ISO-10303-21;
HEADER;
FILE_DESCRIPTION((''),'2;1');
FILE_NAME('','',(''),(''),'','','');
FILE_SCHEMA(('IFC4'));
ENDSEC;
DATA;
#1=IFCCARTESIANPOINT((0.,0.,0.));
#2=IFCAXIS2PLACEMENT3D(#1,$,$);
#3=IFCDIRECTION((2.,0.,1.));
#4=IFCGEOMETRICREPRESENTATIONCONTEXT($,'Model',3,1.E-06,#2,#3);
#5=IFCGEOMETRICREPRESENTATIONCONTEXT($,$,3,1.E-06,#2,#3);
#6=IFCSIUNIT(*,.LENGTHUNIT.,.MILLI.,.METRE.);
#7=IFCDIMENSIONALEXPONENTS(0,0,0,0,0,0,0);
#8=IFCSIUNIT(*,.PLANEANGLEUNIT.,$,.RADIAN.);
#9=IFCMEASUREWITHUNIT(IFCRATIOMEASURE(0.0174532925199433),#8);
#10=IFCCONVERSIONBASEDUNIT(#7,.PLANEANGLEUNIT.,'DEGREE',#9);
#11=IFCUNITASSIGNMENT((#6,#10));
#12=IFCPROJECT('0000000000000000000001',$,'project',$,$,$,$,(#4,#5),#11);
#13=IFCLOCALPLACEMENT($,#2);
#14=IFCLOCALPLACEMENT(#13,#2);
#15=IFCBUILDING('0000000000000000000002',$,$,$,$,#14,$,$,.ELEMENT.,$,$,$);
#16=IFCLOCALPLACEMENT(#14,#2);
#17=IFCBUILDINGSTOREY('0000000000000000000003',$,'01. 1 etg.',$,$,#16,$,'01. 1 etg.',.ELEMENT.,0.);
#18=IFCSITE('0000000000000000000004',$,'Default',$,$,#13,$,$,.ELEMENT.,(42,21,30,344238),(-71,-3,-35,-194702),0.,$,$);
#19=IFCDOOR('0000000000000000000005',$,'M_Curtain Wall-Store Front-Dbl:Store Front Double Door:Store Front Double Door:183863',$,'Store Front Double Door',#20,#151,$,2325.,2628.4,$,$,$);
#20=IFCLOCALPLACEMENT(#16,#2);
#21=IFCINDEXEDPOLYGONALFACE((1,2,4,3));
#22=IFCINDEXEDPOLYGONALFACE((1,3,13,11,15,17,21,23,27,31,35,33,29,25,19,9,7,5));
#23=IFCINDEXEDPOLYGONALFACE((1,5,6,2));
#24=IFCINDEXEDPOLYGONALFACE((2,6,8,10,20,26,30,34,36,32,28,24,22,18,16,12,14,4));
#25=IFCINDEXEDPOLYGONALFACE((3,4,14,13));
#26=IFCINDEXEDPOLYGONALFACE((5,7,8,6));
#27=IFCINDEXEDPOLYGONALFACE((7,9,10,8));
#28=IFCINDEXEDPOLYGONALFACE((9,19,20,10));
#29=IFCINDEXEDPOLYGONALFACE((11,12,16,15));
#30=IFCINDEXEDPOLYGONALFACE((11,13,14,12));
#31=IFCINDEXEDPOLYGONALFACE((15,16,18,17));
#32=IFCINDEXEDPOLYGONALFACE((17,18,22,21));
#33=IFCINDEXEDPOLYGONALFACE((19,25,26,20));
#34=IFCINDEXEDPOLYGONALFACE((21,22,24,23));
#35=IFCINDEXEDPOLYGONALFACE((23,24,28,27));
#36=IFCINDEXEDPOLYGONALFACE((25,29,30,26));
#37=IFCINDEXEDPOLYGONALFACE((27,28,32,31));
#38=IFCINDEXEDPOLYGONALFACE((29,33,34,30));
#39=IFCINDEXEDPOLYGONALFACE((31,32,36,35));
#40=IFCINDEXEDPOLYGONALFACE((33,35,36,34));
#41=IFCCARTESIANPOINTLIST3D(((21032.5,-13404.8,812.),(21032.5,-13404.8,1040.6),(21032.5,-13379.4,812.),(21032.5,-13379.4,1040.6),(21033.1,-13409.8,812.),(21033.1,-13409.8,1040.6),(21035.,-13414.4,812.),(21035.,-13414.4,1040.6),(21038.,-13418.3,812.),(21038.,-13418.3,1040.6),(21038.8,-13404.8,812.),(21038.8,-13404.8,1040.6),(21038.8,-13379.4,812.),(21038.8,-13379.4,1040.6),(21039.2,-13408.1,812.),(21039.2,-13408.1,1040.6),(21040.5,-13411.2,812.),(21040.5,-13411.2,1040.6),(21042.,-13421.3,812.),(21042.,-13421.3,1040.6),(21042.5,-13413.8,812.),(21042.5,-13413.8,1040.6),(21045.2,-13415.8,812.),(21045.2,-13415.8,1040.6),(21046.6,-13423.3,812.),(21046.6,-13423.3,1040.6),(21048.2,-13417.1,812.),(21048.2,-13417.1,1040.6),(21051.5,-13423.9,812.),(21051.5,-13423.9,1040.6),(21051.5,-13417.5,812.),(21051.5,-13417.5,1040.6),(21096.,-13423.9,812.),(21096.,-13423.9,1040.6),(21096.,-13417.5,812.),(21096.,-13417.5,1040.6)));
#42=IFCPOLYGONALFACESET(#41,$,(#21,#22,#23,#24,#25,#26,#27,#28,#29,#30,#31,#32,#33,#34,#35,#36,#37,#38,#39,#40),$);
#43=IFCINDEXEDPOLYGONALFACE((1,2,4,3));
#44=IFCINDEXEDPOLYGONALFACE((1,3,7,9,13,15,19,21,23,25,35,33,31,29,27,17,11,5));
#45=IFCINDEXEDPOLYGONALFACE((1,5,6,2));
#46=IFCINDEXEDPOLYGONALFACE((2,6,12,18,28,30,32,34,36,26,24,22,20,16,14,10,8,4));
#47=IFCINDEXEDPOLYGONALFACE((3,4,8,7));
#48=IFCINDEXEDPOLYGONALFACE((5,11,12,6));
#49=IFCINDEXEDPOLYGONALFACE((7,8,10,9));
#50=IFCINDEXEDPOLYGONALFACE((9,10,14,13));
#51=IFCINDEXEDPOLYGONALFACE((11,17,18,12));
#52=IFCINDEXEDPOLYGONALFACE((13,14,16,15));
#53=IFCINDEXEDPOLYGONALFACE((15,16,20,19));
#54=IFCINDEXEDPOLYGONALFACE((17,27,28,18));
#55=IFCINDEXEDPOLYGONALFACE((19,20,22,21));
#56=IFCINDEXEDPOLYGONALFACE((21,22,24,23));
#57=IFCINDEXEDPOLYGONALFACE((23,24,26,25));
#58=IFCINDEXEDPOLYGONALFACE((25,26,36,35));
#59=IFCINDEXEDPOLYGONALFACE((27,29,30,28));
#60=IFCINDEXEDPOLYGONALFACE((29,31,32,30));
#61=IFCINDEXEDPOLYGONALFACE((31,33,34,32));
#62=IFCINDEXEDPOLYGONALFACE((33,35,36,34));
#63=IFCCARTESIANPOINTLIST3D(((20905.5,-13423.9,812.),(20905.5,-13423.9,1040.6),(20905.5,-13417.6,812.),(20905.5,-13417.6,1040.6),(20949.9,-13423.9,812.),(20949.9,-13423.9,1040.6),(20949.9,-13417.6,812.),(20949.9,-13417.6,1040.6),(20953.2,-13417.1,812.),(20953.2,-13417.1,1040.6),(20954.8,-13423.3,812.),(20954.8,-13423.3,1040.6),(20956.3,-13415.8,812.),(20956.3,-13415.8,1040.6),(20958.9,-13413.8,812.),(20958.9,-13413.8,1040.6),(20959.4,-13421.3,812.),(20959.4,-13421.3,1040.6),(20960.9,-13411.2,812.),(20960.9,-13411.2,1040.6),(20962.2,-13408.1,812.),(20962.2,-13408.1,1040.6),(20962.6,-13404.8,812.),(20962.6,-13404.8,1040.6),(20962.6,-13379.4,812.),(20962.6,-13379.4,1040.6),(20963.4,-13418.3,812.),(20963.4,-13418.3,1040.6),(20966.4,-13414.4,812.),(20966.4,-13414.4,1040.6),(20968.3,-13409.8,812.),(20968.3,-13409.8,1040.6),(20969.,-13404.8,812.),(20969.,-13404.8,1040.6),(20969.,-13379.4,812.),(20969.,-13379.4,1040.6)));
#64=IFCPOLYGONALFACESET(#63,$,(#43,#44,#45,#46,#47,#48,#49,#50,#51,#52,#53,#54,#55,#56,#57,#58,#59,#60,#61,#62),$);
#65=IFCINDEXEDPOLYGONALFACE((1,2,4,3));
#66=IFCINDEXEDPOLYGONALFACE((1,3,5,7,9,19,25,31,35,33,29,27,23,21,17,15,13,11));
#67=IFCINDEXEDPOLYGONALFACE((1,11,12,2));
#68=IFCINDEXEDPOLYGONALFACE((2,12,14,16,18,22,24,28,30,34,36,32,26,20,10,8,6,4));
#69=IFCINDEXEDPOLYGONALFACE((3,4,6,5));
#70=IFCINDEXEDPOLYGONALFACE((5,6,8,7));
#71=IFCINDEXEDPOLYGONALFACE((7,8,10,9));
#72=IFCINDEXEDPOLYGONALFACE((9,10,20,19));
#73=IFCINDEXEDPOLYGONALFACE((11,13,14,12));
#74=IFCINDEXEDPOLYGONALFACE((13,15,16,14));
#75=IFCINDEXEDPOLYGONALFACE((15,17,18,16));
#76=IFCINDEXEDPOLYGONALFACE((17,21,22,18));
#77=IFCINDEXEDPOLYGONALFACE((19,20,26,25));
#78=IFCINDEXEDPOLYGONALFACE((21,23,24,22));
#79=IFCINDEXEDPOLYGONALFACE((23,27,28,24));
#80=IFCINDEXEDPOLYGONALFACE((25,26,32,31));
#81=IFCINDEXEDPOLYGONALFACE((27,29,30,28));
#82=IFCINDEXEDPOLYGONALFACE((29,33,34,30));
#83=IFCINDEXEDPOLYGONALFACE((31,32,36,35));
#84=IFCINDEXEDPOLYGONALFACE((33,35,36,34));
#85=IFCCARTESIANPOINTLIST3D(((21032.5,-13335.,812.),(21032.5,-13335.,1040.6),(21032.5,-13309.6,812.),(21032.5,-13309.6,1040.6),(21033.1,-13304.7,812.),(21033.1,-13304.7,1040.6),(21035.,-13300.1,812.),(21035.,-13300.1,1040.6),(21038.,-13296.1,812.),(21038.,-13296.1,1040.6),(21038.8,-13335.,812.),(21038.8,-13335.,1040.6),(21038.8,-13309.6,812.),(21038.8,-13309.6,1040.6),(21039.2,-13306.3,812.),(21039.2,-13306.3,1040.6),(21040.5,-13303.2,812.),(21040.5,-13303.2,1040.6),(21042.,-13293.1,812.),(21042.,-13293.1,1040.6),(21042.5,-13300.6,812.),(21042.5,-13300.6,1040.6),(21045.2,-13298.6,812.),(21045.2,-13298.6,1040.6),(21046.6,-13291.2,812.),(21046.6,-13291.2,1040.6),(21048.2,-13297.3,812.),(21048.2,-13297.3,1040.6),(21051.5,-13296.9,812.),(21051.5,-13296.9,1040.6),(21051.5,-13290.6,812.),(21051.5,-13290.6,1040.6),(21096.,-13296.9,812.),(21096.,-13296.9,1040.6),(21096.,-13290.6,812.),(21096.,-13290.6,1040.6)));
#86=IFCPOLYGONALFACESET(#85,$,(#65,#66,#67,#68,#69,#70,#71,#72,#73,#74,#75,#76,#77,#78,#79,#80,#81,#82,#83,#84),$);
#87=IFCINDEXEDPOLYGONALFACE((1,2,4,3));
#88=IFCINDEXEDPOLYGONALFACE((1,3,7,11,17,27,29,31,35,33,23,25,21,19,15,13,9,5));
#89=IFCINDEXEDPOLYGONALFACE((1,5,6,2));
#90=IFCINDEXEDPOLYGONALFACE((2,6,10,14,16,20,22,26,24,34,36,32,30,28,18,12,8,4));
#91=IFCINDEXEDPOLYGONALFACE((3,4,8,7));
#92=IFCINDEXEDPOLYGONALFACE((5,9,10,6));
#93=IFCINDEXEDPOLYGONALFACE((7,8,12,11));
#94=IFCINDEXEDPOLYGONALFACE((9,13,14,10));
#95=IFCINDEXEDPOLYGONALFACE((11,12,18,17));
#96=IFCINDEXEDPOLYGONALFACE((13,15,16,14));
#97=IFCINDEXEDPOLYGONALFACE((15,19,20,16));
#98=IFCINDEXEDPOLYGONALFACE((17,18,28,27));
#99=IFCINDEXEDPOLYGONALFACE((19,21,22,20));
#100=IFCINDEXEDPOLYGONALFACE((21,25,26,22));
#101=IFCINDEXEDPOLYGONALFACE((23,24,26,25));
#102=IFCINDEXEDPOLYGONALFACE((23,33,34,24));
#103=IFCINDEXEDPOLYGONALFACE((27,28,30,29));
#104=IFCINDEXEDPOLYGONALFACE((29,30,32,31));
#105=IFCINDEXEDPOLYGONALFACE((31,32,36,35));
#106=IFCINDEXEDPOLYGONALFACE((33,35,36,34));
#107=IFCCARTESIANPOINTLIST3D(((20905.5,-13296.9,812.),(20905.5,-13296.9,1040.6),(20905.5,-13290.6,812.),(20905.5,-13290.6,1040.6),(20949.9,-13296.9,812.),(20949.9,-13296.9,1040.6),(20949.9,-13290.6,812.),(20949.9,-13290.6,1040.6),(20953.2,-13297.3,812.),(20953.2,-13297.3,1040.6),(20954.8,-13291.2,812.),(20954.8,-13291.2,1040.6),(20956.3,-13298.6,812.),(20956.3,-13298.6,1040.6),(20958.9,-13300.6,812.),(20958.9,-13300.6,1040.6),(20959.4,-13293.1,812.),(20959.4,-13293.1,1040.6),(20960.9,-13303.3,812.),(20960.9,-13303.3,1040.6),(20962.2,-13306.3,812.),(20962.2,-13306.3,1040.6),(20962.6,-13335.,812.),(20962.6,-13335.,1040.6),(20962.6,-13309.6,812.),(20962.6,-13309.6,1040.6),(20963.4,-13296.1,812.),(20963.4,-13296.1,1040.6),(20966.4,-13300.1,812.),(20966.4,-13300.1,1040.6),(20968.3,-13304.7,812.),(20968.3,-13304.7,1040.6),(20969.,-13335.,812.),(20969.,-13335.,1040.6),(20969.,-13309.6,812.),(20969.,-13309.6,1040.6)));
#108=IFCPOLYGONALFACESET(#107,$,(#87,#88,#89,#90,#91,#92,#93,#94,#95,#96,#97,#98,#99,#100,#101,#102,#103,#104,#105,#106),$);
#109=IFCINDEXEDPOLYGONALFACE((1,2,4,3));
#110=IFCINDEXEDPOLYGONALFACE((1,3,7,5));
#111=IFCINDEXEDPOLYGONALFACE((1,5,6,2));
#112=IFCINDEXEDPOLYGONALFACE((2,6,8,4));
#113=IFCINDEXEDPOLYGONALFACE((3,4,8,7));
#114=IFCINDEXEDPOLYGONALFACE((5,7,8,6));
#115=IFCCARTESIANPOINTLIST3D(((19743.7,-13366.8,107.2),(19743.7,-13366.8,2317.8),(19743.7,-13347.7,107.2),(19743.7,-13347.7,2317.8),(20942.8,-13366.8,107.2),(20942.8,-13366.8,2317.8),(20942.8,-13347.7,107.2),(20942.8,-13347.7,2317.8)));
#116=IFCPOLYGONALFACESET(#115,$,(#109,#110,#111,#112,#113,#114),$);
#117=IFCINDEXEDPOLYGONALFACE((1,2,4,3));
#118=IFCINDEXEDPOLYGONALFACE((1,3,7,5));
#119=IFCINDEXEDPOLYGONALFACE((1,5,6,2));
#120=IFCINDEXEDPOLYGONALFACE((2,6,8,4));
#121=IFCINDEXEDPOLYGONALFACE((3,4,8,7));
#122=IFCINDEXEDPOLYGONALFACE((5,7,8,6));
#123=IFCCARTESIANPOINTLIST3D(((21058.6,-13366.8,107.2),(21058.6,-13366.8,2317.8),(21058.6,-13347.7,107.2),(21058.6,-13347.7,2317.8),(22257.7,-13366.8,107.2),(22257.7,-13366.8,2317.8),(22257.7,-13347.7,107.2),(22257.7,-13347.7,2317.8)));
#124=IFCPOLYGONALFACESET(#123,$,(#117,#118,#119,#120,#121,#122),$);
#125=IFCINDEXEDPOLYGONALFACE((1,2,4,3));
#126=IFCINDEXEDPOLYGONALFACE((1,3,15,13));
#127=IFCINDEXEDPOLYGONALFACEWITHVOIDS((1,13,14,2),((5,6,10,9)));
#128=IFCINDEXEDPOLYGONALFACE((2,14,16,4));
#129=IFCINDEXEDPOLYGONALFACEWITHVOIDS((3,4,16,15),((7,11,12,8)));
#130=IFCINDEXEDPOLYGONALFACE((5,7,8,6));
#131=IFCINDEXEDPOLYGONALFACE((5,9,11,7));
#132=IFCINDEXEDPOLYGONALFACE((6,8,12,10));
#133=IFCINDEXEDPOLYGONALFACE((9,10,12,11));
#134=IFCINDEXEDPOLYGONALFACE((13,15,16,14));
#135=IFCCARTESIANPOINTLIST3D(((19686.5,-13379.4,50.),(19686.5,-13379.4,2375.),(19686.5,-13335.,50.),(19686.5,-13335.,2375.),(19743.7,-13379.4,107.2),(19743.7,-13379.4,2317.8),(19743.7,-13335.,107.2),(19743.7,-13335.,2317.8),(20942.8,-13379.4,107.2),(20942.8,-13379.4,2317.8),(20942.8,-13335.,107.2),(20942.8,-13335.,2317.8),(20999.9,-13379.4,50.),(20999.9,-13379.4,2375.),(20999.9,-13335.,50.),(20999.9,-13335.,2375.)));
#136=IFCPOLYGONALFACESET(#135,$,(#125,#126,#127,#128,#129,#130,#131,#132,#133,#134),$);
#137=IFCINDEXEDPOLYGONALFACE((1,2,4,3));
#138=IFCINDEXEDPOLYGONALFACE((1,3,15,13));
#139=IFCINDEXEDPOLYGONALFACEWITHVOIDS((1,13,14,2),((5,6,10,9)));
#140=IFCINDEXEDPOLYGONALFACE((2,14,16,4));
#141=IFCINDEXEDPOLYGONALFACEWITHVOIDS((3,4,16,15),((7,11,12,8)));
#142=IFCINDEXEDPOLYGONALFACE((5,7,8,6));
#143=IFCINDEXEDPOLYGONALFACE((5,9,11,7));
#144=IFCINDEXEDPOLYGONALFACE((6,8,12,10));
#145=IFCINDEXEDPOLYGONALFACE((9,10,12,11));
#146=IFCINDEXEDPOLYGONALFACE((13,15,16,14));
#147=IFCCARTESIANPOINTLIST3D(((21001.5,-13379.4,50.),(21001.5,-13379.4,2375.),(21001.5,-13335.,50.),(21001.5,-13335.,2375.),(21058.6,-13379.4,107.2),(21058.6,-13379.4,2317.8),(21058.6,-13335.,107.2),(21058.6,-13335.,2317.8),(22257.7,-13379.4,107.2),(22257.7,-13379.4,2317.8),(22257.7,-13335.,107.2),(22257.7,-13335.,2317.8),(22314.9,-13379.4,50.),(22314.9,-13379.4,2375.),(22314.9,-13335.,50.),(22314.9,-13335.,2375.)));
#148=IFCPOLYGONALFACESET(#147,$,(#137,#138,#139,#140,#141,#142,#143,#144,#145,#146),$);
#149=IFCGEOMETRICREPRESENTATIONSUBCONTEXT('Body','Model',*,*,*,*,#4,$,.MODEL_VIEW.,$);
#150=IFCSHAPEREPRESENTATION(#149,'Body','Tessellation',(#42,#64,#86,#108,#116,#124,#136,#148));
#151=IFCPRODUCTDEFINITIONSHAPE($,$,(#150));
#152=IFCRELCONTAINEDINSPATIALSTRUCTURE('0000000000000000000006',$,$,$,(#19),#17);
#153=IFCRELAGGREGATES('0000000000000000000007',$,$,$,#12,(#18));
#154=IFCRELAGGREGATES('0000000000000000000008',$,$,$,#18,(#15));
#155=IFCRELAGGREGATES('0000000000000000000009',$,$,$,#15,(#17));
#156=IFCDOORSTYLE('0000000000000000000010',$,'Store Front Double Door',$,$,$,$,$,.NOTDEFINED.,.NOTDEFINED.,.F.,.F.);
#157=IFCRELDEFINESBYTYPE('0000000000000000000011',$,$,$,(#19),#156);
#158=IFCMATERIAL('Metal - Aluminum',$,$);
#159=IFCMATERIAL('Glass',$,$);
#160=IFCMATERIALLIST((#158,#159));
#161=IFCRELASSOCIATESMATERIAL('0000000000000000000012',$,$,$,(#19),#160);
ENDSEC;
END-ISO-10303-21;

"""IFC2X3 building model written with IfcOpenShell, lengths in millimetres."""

from ifc_helpers import new_model, entity, si_unit, converted_unit, direction, frame, frame_2d, origin, place, context, subcontext, project, spatial, polyline, circle_curve, parameter, trimmed, segment, composite_curve, rectangle, outline, extrude, source, transform, mapped, material, material_list, type_object, type_shapes, element, save


model = new_model("IFC2X3")

# Units and contexts
model_context = context("Model", 3, precision=1e-06, world=origin(), true_north=direction((2.0, 0.0, 1.0)))
context_of_model = context(None, 3, precision=1e-06, world=origin(), true_north=direction((2.0, 0.0, 1.0)))
body_context = subcontext(model_context, "Body", "Model", "MODEL_VIEW")
ifc_project = project(units=[si_unit("LENGTHUNIT", "METRE", prefix="MILLI"), converted_unit("PLANEANGLEUNIT", "DEGREE", entity("IfcRatioMeasure", 0.0174532925199433), si_unit("PLANEANGLEUNIT", "RADIAN"), dimensions=[0, 0, 0, 0, 0, 0, 0])], contexts=[model_context, context_of_model])

# Site, building, storey
site_placement = place(None, origin())
site = spatial("IfcSite", under=ifc_project, at=site_placement, Name="Default", CompositionType="ELEMENT", RefLatitude=(42, 21, 30, 344238), RefLongitude=(-71, -3, -35, -194702), RefElevation=0.0)
building_placement = place(site_placement, origin())
building = spatial("IfcBuilding", under=site, at=building_placement, CompositionType="ELEMENT")
storey_placement = place(building_placement, origin())
storey = spatial("IfcBuildingStorey", under=building, at=storey_placement, Name="01. 1 etg.", LongName="01. 1 etg.", CompositionType="ELEMENT", Elevation=0.0)

# Shared definitions
ifc_material_1 = material(Name="Glass")

# Door
ifc_material_2 = material(Name="Metal - Aluminum")
ifc_material_list_1 = material_list([ifc_material_2, ifc_material_1])
door_style_1 = type_object("IfcDoorStyle", Name="Store Front Double Door", ConstructionType="NOTDEFINED", OperationType="NOTDEFINED", ParameterTakesPrecedence=False, Sizeable=False)
shared_shape_1 = source(origin(), body_context, "Body", "SweptSolid", [
    extrude(outline(composite_curve([segment(trimmed(circle_curve(frame_2d((-3.2, 1.6), x_axis=(1.0, 0.0)), 19.0), [parameter(180.0)], [parameter(270.0)], True, "PARAMETER"), True, "CONTINUOUS"), segment(polyline([(-3.2, -17.5), (41.3, -17.5)]), True, "CONTINUOUS"), segment(polyline([(41.3, -17.5), (41.3, -11.1)]), True, "CONTINUOUS"), segment(polyline([(41.3, -11.1), (-3.2, -11.1)]), True, "CONTINUOUS"), segment(trimmed(circle_curve(frame_2d((-3.2, 1.6), x_axis=(1.0, 0.0)), 12.7), [parameter(180.0)], [parameter(270.0)], True, "PARAMETER"), False, "CONTINUOUS"), segment(polyline([(-15.9, 1.6), (-15.9, 27.0)]), True, "CONTINUOUS"), segment(polyline([(-15.9, 27.0), (-22.2, 27.0)]), True, "CONTINUOUS"), segment(polyline([(-22.2, 27.0), (-22.2, 1.6)]), True, "CONTINUOUS")], self_intersect=False)), frame((54.0, -16.4, 762.0)), (0.0, 0.0, 1.0), 228.6),
    extrude(outline(composite_curve([segment(polyline([(1.6, -22.2), (27.0, -22.2)]), True, "CONTINUOUS"), segment(polyline([(27.0, -22.2), (27.0, -15.9)]), True, "CONTINUOUS"), segment(polyline([(27.0, -15.9), (1.6, -15.9)]), True, "CONTINUOUS"), segment(trimmed(circle_curve(frame_2d((1.6, -3.2), x_axis=(0.0, -1.0)), 12.7), [parameter(270.0)], [parameter(0.0)], True, "PARAMETER"), False, "CONTINUOUS"), segment(polyline([(-11.1, -3.2), (-11.1, 41.3)]), True, "CONTINUOUS"), segment(polyline([(-11.1, 41.3), (-17.5, 41.3)]), True, "CONTINUOUS"), segment(polyline([(-17.5, 41.3), (-17.5, -3.2)]), True, "CONTINUOUS"), segment(trimmed(circle_curve(frame_2d((1.6, -3.2), x_axis=(0.0, -1.0)), 19.1), [parameter(270.0)], [parameter(360.0)], True, "PARAMETER"), True, "CONTINUOUS")], self_intersect=False)), frame((-54.0, -16.4, 762.0), z_axis=(0.0, 0.0, 1.0), x_axis=(0.0, 1.0, 0.0)), (0.0, 0.0, 1.0), 228.6),
    extrude(outline(composite_curve([segment(polyline([(1.6, -22.2), (27.0, -22.2)]), True, "CONTINUOUS"), segment(polyline([(27.0, -22.2), (27.0, -15.9)]), True, "CONTINUOUS"), segment(polyline([(27.0, -15.9), (1.6, -15.9)]), True, "CONTINUOUS"), segment(trimmed(circle_curve(frame_2d((1.6, -3.2), x_axis=(0.0, 1.0)), 12.7), [parameter(90.0)], [parameter(180.0)], True, "PARAMETER"), False, "CONTINUOUS"), segment(polyline([(-11.1, -3.2), (-11.1, 41.3)]), True, "CONTINUOUS"), segment(polyline([(-11.1, 41.3), (-17.5, 41.3)]), True, "CONTINUOUS"), segment(polyline([(-17.5, 41.3), (-17.5, -3.2)]), True, "CONTINUOUS"), segment(trimmed(circle_curve(frame_2d((1.6, -3.2), x_axis=(0.0, 1.0)), 19.1), [parameter(90.0)], [parameter(180.0)], True, "PARAMETER"), True, "CONTINUOUS")], self_intersect=False)), frame((54.0, 82.0, 762.0), z_axis=(0.0, 0.0, 1.0), x_axis=(0.0, -1.0, 0.0)), (0.0, 0.0, 1.0), 228.6),
    extrude(outline(composite_curve([segment(trimmed(circle_curve(frame_2d((3.2, -1.6), x_axis=(1.0, 0.0)), 19.0), [parameter(0.0)], [parameter(90.0)], True, "PARAMETER"), True, "CONTINUOUS"), segment(polyline([(3.2, 17.5), (-41.3, 17.5)]), True, "CONTINUOUS"), segment(polyline([(-41.3, 17.5), (-41.3, 11.1)]), True, "CONTINUOUS"), segment(polyline([(-41.3, 11.1), (3.2, 11.1)]), True, "CONTINUOUS"), segment(trimmed(circle_curve(frame_2d((3.2, -1.6), x_axis=(1.0, 0.0)), 12.7), [parameter(0.0)], [parameter(90.0)], True, "PARAMETER"), False, "CONTINUOUS"), segment(polyline([(15.9, -1.6), (15.9, -27.0)]), True, "CONTINUOUS"), segment(polyline([(15.9, -27.0), (22.2, -27.0)]), True, "CONTINUOUS"), segment(polyline([(22.2, -27.0), (22.2, -1.6)]), True, "CONTINUOUS")], self_intersect=False)), frame((-54.0, 82.0, 762.0)), (0.0, 0.0, 1.0), 228.6),
    extrude(rectangle(XDim=19.0, YDim=1199.1, at=frame_2d((0.0, 0.0), x_axis=(1.0, 0.0))), frame((-657.5, 32.8, 57.1), z_axis=(0.0, 0.0, 1.0), x_axis=(0.0, 1.0, 0.0)), (0.0, 0.0, 1.0), 2210.7),
    extrude(rectangle(XDim=19.0, YDim=1199.1, at=frame_2d((0.0, 0.0), x_axis=(1.0, 0.0))), frame((657.5, 32.8, 57.1), z_axis=(0.0, 0.0, 1.0), x_axis=(0.0, 1.0, 0.0)), (0.0, 0.0, 1.0), 2210.7),
    extrude(outline(polyline([(-1162.5, -656.7), (1162.5, -656.7), (1162.5, 656.7), (-1162.5, 656.7), (-1162.5, -656.7)]), holes=[polyline([(-1105.3, 599.5), (1105.3, 599.5), (1105.3, -599.5), (-1105.3, -599.5), (-1105.3, 599.5)])]), frame((-657.5, 10.5, 1162.5), z_axis=(0.0, 1.0, 0.0), x_axis=(0.0, 0.0, -1.0)), (0.0, 0.0, 1.0), 44.5),
    extrude(outline(polyline([(-656.7, -1162.5), (656.7, -1162.5), (656.7, 1162.5), (-656.7, 1162.5), (-656.7, -1162.5)]), holes=[polyline([(-599.5, -1105.3), (-599.5, 1105.3), (599.5, 1105.3), (599.5, -1105.3), (-599.5, -1105.3)])]), frame((657.5, 10.5, 1162.5), z_axis=(0.0, 1.0, 0.0), x_axis=(1.0, 0.0, 0.0)), (0.0, 0.0, 1.0), 44.5),
])
type_shapes(door_style_1, [shared_shape_1])
door_1_placement = place(storey_placement, frame((21000.7, -13390.0, 50.0)))
element("IfcDoor", 1, at=door_1_placement, inside=storey, type_object=door_style_1, material=ifc_material_list_1, Name="M_Curtain Wall-Store Front-Dbl:Store Front Double Door:Store Front Double Door:183863", ObjectType="Store Front Double Door", OverallHeight=2325.0, OverallWidth=2628.4, context=body_context, shape_type="MappedRepresentation", body=[
    mapped(shared_shape_1, transform((0.0, 0.0, 0.0), scale=1.0)),
])

save(model, "model.ifc")
